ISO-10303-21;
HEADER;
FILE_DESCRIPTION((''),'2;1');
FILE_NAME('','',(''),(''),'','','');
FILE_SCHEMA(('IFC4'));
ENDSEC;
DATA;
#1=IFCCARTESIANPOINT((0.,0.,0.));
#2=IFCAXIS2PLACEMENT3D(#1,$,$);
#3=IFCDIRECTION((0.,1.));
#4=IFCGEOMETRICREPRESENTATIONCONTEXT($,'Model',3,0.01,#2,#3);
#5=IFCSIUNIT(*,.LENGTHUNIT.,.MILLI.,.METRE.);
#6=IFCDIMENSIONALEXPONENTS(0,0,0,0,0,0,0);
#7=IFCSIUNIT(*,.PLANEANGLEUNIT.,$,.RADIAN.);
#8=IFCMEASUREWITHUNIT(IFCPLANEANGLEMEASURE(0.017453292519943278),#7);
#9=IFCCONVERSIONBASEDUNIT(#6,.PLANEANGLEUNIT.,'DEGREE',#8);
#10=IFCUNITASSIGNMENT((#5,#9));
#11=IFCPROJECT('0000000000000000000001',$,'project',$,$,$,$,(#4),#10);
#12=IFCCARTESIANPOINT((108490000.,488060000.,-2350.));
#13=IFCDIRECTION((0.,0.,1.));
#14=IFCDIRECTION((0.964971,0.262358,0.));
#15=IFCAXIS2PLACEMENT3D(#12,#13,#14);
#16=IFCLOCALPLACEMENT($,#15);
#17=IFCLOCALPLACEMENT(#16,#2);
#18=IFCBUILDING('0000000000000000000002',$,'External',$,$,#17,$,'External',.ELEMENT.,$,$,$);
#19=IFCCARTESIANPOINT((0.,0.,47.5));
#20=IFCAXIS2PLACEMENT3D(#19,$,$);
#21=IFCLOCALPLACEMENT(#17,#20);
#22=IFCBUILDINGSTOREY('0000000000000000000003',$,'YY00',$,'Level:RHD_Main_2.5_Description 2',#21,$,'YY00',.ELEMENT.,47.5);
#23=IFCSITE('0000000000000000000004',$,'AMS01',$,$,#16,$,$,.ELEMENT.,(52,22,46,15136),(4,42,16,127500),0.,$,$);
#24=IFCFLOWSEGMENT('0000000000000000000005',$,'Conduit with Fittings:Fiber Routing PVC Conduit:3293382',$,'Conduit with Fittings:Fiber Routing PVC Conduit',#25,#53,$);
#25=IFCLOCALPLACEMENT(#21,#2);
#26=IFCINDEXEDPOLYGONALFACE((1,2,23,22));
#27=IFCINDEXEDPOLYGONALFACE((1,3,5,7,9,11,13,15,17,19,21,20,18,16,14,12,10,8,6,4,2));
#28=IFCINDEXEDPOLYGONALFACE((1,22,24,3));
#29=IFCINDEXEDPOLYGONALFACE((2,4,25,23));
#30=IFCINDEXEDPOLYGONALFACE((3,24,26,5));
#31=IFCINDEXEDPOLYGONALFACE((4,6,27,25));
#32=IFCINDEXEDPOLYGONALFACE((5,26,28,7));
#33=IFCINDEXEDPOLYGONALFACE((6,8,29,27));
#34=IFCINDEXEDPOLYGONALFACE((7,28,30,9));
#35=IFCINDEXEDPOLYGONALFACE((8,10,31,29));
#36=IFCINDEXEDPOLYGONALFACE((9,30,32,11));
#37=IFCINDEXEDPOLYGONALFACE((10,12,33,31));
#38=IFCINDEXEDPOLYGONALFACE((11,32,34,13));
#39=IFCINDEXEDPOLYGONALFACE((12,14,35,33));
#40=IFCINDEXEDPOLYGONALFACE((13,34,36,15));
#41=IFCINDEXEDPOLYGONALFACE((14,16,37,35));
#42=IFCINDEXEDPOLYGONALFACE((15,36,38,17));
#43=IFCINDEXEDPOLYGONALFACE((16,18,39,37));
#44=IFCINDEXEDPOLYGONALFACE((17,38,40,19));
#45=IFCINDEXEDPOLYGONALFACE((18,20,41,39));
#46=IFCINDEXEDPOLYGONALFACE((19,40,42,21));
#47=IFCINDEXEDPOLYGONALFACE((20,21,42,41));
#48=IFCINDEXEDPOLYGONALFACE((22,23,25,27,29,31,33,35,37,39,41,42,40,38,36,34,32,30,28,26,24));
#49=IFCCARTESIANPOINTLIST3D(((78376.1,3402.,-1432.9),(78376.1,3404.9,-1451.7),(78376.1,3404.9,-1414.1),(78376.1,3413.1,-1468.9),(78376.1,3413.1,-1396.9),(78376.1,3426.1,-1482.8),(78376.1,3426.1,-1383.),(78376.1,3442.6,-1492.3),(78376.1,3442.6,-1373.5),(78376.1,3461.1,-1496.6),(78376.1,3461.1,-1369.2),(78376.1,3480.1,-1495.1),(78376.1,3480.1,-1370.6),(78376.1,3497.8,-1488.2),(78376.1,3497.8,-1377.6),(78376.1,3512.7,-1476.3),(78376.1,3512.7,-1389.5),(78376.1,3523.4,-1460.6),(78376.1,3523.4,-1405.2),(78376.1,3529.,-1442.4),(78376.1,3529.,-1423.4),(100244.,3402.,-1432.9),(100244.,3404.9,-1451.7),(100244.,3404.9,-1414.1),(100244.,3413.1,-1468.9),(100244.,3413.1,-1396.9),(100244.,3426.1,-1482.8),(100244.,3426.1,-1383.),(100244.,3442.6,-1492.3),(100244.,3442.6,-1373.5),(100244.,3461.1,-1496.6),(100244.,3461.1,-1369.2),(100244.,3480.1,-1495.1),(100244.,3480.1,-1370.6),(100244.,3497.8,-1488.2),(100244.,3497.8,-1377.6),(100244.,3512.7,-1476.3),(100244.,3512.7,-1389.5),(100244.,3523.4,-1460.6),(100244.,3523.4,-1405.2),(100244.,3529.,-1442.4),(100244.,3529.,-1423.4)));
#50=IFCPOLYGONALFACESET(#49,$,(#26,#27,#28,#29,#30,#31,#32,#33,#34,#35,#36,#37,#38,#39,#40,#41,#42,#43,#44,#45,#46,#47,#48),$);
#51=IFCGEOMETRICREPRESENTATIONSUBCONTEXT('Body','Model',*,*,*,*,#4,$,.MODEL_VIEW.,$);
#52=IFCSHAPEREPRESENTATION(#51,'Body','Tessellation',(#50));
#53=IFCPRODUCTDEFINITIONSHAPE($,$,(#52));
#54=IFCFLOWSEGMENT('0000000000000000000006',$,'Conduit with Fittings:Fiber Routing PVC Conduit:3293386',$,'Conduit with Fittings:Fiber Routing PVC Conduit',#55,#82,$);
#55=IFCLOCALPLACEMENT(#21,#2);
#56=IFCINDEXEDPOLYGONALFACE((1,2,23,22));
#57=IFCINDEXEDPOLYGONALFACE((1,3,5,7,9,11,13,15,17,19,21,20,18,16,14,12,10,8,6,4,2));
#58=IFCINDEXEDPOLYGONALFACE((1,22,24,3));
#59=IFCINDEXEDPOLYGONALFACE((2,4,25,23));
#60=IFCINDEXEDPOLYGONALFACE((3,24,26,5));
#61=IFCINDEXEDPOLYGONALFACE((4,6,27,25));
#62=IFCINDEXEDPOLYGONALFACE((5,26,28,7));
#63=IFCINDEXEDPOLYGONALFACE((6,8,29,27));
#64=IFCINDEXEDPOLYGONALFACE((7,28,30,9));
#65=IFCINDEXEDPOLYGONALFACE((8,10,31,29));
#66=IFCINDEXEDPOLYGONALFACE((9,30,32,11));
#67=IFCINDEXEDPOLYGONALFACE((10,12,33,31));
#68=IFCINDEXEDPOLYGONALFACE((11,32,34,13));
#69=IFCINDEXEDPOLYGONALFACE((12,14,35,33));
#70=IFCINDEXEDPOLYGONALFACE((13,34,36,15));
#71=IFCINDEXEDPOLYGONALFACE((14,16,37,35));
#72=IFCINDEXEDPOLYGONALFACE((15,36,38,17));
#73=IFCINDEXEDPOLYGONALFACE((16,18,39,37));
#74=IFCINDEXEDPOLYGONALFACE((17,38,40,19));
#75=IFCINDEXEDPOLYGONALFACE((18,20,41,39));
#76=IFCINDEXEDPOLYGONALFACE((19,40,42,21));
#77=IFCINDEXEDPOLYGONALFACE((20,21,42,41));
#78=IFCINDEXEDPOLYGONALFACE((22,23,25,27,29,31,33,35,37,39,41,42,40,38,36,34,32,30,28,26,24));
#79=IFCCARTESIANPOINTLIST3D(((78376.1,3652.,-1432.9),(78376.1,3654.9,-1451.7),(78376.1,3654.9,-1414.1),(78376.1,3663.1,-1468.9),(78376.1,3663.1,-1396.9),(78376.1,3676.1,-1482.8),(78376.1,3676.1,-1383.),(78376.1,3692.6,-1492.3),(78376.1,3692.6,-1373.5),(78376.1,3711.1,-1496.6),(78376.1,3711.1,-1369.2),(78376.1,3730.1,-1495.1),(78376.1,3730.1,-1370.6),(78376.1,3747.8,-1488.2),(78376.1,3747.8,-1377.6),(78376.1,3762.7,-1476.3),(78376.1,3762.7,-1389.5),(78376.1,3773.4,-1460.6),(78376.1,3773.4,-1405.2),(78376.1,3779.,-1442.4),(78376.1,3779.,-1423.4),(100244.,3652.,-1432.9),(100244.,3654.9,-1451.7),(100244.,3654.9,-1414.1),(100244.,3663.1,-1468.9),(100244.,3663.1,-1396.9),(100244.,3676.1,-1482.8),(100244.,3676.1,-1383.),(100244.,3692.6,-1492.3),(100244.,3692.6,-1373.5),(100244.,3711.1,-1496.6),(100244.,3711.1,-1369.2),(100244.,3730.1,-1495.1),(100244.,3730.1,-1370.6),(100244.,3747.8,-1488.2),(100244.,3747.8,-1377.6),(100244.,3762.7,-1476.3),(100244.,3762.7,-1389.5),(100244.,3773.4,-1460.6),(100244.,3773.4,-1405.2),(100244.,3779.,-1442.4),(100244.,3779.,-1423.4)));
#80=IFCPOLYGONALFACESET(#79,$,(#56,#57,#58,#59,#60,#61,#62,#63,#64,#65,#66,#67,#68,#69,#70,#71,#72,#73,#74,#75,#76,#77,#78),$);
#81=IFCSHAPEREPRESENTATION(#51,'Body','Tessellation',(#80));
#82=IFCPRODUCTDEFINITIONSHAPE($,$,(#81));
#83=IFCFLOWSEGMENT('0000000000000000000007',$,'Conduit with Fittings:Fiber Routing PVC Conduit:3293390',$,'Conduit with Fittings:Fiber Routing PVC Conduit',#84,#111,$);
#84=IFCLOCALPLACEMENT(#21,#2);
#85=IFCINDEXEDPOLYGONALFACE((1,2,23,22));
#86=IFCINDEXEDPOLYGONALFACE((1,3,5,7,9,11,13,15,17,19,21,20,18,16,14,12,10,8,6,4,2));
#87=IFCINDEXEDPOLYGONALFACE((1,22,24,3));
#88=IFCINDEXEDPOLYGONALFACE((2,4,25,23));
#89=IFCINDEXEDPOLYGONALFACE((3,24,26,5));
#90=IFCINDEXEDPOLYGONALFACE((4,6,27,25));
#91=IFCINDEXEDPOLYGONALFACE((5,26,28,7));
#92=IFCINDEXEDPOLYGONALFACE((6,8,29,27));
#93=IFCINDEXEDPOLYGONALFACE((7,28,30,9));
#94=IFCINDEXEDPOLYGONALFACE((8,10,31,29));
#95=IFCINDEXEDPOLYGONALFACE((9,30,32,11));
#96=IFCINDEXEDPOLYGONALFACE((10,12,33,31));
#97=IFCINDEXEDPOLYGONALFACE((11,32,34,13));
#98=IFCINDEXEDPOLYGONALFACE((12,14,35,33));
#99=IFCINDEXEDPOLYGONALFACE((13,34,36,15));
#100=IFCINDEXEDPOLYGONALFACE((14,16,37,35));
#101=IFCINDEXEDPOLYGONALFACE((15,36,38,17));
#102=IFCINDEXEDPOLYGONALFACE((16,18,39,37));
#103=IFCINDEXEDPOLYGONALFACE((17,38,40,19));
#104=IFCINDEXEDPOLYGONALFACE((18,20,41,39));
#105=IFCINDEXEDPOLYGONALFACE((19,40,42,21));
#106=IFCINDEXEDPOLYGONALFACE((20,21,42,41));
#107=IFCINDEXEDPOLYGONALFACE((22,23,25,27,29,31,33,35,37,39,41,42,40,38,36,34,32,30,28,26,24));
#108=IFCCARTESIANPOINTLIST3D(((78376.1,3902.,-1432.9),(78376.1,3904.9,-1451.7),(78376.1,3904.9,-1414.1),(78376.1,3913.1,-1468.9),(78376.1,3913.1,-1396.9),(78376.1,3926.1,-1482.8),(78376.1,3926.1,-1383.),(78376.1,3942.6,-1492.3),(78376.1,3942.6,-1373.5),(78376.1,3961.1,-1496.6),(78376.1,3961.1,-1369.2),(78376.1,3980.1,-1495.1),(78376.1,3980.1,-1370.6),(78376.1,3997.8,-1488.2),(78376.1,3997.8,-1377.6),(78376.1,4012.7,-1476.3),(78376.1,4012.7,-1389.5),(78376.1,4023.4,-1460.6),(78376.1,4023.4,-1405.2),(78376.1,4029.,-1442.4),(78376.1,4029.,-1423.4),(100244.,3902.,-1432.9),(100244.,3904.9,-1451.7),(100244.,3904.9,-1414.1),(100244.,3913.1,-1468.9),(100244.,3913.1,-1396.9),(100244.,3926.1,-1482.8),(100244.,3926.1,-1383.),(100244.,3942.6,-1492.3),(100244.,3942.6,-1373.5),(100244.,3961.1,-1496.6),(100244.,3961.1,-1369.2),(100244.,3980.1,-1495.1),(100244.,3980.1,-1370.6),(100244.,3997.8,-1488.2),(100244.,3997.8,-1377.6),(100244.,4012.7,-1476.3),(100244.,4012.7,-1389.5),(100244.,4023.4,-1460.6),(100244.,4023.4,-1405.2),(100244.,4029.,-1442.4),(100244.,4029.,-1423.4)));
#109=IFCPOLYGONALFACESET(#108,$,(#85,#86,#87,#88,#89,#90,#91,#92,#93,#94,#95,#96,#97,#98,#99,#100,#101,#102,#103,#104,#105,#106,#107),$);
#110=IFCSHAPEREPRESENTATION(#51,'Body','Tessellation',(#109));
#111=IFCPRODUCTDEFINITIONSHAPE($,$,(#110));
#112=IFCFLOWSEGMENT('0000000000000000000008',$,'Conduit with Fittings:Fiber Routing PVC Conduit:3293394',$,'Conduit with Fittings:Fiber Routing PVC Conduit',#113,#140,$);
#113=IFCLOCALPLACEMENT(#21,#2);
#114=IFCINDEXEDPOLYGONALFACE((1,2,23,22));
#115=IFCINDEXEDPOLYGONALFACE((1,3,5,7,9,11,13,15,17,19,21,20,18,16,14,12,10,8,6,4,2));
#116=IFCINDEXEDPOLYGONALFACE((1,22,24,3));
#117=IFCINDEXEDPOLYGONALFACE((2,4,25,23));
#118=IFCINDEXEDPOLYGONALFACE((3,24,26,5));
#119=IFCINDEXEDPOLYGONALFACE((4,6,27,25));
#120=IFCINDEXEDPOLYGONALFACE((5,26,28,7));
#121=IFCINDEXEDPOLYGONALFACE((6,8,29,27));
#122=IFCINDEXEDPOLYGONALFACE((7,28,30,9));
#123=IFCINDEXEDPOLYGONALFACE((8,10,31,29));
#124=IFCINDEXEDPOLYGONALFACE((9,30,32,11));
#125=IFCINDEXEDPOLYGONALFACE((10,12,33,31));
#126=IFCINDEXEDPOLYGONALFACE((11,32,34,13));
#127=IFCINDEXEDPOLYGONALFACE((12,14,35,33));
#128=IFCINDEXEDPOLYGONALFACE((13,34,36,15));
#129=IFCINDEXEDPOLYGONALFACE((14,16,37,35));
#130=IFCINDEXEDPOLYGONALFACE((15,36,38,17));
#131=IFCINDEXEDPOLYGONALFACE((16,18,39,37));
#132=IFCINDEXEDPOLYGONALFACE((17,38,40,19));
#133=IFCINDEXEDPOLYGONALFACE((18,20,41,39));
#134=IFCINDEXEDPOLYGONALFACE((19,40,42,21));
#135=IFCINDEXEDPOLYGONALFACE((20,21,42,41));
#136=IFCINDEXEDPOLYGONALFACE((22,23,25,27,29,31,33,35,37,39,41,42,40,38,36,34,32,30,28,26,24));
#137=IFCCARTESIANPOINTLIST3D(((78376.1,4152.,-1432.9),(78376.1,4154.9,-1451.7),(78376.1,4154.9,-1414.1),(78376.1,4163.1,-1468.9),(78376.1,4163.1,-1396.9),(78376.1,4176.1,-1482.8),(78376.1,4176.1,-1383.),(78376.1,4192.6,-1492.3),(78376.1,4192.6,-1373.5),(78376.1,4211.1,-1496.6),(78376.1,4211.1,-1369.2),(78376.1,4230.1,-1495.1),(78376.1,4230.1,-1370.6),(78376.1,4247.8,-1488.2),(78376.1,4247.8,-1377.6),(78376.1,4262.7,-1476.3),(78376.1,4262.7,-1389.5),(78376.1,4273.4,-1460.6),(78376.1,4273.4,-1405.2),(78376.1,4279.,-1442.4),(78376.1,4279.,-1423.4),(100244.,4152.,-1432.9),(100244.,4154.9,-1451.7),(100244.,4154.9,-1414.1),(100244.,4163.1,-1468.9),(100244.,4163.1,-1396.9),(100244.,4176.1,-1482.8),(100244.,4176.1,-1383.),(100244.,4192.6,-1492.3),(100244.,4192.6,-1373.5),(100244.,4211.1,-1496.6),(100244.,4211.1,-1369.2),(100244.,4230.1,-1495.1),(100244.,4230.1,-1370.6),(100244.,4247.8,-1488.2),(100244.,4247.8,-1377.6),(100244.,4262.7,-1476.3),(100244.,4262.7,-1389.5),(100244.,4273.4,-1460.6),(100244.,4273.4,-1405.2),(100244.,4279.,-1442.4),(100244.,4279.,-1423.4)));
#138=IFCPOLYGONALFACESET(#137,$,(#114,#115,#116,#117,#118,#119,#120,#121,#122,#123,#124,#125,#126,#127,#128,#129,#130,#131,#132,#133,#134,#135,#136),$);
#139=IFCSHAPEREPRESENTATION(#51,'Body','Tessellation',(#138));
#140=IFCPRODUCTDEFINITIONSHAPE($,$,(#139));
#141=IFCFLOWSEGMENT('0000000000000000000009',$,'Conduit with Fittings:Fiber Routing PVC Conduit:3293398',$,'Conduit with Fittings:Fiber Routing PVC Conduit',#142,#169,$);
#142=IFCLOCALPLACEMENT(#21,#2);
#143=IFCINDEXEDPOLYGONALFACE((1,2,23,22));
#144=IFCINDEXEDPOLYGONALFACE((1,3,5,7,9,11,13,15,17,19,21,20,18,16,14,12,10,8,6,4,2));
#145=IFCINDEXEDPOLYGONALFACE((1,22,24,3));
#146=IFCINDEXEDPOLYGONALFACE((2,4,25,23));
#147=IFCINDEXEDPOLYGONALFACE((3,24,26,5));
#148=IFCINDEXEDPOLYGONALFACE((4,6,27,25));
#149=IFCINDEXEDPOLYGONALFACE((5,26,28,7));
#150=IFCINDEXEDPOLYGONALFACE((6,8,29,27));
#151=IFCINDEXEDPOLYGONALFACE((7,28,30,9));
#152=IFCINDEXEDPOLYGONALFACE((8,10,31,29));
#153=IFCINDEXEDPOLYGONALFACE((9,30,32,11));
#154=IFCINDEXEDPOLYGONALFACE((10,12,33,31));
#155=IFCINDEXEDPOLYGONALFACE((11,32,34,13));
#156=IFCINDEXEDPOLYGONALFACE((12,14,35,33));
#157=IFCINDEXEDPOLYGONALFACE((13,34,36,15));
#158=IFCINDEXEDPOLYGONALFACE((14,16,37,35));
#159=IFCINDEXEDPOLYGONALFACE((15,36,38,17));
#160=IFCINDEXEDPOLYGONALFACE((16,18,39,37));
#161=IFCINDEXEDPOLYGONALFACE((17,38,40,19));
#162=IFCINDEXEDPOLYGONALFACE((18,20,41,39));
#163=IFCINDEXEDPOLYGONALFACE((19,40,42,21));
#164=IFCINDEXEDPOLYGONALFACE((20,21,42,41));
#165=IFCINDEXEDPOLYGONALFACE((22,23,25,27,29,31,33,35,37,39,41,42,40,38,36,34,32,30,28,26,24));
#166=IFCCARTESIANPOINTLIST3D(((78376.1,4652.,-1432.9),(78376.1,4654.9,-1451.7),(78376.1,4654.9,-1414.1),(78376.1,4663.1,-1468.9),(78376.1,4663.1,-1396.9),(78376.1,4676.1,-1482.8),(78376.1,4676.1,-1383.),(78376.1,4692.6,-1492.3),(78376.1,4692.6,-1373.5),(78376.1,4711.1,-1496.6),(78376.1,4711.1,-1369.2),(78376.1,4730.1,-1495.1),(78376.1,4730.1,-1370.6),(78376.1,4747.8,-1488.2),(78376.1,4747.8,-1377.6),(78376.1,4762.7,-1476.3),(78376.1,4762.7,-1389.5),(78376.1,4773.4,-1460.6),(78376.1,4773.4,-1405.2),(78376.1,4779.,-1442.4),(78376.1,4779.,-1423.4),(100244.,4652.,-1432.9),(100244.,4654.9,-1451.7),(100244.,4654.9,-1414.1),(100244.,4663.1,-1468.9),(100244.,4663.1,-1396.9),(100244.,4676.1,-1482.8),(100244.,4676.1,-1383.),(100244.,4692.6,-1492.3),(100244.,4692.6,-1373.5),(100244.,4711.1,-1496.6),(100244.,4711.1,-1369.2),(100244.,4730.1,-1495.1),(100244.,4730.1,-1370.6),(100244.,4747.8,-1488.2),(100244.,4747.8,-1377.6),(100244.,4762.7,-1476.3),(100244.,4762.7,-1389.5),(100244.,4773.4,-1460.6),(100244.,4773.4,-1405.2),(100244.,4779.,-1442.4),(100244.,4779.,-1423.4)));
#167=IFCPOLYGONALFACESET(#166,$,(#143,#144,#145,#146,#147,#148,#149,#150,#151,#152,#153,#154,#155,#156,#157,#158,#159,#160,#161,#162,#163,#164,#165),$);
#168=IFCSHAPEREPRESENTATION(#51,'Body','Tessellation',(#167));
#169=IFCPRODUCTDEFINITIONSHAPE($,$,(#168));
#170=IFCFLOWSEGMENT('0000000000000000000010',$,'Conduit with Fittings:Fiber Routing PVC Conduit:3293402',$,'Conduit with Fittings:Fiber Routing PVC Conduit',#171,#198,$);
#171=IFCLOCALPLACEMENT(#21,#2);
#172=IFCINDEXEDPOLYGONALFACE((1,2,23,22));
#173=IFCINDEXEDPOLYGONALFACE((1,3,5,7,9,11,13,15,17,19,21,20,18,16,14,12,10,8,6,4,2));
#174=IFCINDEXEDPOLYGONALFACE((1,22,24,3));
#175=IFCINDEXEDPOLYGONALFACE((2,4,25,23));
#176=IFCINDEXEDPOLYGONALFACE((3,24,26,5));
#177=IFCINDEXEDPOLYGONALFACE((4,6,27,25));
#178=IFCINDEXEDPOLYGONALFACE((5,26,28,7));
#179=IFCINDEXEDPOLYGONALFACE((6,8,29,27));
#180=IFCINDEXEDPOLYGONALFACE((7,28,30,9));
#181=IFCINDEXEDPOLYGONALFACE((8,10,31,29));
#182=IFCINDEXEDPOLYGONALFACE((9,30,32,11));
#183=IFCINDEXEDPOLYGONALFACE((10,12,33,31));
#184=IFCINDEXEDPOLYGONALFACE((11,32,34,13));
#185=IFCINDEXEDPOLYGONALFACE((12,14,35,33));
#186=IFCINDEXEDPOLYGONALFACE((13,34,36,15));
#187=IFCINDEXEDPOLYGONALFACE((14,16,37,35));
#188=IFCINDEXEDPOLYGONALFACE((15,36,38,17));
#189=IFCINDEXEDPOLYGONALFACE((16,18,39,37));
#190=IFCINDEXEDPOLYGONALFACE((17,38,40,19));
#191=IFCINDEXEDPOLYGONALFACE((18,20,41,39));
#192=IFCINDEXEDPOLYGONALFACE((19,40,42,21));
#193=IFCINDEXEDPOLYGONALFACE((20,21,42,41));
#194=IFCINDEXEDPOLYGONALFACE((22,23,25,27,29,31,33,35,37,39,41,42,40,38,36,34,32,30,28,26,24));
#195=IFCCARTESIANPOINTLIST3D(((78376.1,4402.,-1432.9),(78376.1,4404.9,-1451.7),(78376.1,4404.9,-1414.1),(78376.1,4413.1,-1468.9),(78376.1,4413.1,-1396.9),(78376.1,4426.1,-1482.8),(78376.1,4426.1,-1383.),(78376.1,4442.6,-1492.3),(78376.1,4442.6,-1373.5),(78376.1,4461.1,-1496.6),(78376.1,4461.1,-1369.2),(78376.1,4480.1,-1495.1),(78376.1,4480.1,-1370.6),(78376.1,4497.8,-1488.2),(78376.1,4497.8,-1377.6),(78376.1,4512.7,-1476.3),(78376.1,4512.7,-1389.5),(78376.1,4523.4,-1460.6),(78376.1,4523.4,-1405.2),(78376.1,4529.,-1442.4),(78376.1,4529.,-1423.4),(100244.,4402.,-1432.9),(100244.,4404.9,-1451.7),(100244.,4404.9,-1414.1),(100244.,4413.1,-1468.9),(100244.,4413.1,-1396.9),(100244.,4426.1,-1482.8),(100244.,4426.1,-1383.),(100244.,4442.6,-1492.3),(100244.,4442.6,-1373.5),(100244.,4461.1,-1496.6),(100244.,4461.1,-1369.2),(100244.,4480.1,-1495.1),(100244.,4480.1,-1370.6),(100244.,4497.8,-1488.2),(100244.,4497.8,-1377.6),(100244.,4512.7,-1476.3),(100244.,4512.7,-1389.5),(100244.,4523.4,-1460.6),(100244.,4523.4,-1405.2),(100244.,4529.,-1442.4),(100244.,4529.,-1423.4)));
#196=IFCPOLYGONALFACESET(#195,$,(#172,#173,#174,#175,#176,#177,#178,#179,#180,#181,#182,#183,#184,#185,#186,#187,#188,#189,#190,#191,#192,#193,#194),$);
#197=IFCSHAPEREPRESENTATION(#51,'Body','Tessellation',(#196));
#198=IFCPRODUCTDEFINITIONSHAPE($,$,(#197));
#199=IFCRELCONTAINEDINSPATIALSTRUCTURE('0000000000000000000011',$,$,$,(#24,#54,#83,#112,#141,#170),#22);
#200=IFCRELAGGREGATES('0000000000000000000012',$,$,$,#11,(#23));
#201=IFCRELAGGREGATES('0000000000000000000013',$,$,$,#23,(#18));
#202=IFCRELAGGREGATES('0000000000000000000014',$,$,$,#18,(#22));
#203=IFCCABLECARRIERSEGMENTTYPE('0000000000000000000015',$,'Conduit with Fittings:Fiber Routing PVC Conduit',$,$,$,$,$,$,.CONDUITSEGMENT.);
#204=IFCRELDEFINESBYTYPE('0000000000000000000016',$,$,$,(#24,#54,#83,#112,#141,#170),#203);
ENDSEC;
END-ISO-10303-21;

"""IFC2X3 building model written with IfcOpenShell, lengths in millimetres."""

from ifc_helpers import new_model, entity, si_unit, converted_unit, direction, frame, frame_2d, origin, origin_2d_with_axis, place, context, subcontext, project, spatial, circle, extrude, type_object, element, save


model = new_model("IFC2X3")

# Units and contexts
model_context = context("Model", 3, precision=0.01, world=origin(), true_north=direction((0.0, 1.0)))
body_context = subcontext(model_context, "Body", "Model", "MODEL_VIEW")
ifc_project = project(units=[si_unit("LENGTHUNIT", "METRE", prefix="MILLI"), converted_unit("PLANEANGLEUNIT", "DEGREE", entity("IfcPlaneAngleMeasure", 0.017453292519943278), si_unit("PLANEANGLEUNIT", "RADIAN"), dimensions=[0, 0, 0, 0, 0, 0, 0])], contexts=[model_context])

# Site, building, storey
site_placement = place(None, frame((108490000.0, 488060000.0, -2350.0), z_axis=(0.0, 0.0, 1.0), x_axis=(0.964971, 0.262358, 0.0)))
site = spatial("IfcSite", under=ifc_project, at=site_placement, Name="AMS01", CompositionType="ELEMENT", RefLatitude=(52, 22, 46, 15136), RefLongitude=(4, 42, 16, 127500), RefElevation=0.0)
building_placement = place(site_placement, origin())
building = spatial("IfcBuilding", under=site, at=building_placement, Name="External", LongName="External", CompositionType="ELEMENT")
storey_placement = place(building_placement, frame((0.0, 0.0, 47.5)))
storey = spatial("IfcBuildingStorey", under=building, at=storey_placement, Name="YY00", ObjectType="Level:RHD_Main_2.5_Description 2", LongName="YY00", CompositionType="ELEMENT", Elevation=47.5)

# Flow segments
cable_carrier_segment_type = type_object("IfcCableCarrierSegmentType", Name="Conduit with Fittings:Fiber Routing PVC Conduit", PredefinedType="CONDUITSEGMENT")
flow_segment_1_placement = place(storey_placement, origin())
element("IfcFlowSegment", 1, at=flow_segment_1_placement, inside=storey, type_object=cable_carrier_segment_type, Name="Conduit with Fittings:Fiber Routing PVC Conduit:3293382", ObjectType="Conduit with Fittings:Fiber Routing PVC Conduit", context=body_context, shape_type="SweptSolid", body=[
    extrude(circle(Radius=63.9, at=origin_2d_with_axis()), frame((78376.1, 3465.9, -1432.9), z_axis=(1.0, 0.0, 0.0), x_axis=(0.0, -1.0, 0.0)), (0.0, 0.0, 1.0), 21867.9),
])
flow_segment_2_placement = place(storey_placement, origin())
element("IfcFlowSegment", 2, at=flow_segment_2_placement, inside=storey, type_object=cable_carrier_segment_type, Name="Conduit with Fittings:Fiber Routing PVC Conduit:3293386", ObjectType="Conduit with Fittings:Fiber Routing PVC Conduit", context=body_context, shape_type="SweptSolid", body=[
    extrude(circle(Radius=63.9, at=frame_2d((0.0, 0.0), x_axis=(1.0, 0.0))), frame((78376.1, 3715.9, -1432.9), z_axis=(1.0, 0.0, 0.0), x_axis=(0.0, -1.0, 0.0)), (0.0, 0.0, 1.0), 21867.9),
])
flow_segment_3_placement = place(storey_placement, origin())
element("IfcFlowSegment", 3, at=flow_segment_3_placement, inside=storey, type_object=cable_carrier_segment_type, Name="Conduit with Fittings:Fiber Routing PVC Conduit:3293390", ObjectType="Conduit with Fittings:Fiber Routing PVC Conduit", context=body_context, shape_type="SweptSolid", body=[
    extrude(circle(Radius=63.9, at=frame_2d((0.0, 0.0), x_axis=(1.0, 0.0))), frame((78376.1, 3965.9, -1432.9), z_axis=(1.0, 0.0, 0.0), x_axis=(0.0, -1.0, 0.0)), (0.0, 0.0, 1.0), 21867.9),
])
flow_segment_4_placement = place(storey_placement, origin())
element("IfcFlowSegment", 4, at=flow_segment_4_placement, inside=storey, type_object=cable_carrier_segment_type, Name="Conduit with Fittings:Fiber Routing PVC Conduit:3293394", ObjectType="Conduit with Fittings:Fiber Routing PVC Conduit", context=body_context, shape_type="SweptSolid", body=[
    extrude(circle(Radius=63.9, at=origin_2d_with_axis()), frame((78376.1, 4215.9, -1432.9), z_axis=(1.0, 0.0, 0.0), x_axis=(0.0, -1.0, 0.0)), (0.0, 0.0, 1.0), 21867.9),
])
flow_segment_5_placement = place(storey_placement, origin())
element("IfcFlowSegment", 5, at=flow_segment_5_placement, inside=storey, type_object=cable_carrier_segment_type, Name="Conduit with Fittings:Fiber Routing PVC Conduit:3293398", ObjectType="Conduit with Fittings:Fiber Routing PVC Conduit", context=body_context, shape_type="SweptSolid", body=[
    extrude(circle(Radius=63.9, at=origin_2d_with_axis()), frame((78376.1, 4715.9, -1432.9), z_axis=(1.0, 0.0, 0.0), x_axis=(0.0, -1.0, 0.0)), (0.0, 0.0, 1.0), 21867.9),
])
flow_segment_6_placement = place(storey_placement, origin())
element("IfcFlowSegment", 6, at=flow_segment_6_placement, inside=storey, type_object=cable_carrier_segment_type, Name="Conduit with Fittings:Fiber Routing PVC Conduit:3293402", ObjectType="Conduit with Fittings:Fiber Routing PVC Conduit", context=body_context, shape_type="SweptSolid", body=[
    extrude(circle(Radius=63.9, at=frame_2d((0.0, 0.0), x_axis=(1.0, 0.0))), frame((78376.1, 4465.9, -1432.9), z_axis=(1.0, 0.0, 0.0), x_axis=(0.0, -1.0, 0.0)), (0.0, 0.0, 1.0), 21867.9),
])

save(model, "model.ifc")
